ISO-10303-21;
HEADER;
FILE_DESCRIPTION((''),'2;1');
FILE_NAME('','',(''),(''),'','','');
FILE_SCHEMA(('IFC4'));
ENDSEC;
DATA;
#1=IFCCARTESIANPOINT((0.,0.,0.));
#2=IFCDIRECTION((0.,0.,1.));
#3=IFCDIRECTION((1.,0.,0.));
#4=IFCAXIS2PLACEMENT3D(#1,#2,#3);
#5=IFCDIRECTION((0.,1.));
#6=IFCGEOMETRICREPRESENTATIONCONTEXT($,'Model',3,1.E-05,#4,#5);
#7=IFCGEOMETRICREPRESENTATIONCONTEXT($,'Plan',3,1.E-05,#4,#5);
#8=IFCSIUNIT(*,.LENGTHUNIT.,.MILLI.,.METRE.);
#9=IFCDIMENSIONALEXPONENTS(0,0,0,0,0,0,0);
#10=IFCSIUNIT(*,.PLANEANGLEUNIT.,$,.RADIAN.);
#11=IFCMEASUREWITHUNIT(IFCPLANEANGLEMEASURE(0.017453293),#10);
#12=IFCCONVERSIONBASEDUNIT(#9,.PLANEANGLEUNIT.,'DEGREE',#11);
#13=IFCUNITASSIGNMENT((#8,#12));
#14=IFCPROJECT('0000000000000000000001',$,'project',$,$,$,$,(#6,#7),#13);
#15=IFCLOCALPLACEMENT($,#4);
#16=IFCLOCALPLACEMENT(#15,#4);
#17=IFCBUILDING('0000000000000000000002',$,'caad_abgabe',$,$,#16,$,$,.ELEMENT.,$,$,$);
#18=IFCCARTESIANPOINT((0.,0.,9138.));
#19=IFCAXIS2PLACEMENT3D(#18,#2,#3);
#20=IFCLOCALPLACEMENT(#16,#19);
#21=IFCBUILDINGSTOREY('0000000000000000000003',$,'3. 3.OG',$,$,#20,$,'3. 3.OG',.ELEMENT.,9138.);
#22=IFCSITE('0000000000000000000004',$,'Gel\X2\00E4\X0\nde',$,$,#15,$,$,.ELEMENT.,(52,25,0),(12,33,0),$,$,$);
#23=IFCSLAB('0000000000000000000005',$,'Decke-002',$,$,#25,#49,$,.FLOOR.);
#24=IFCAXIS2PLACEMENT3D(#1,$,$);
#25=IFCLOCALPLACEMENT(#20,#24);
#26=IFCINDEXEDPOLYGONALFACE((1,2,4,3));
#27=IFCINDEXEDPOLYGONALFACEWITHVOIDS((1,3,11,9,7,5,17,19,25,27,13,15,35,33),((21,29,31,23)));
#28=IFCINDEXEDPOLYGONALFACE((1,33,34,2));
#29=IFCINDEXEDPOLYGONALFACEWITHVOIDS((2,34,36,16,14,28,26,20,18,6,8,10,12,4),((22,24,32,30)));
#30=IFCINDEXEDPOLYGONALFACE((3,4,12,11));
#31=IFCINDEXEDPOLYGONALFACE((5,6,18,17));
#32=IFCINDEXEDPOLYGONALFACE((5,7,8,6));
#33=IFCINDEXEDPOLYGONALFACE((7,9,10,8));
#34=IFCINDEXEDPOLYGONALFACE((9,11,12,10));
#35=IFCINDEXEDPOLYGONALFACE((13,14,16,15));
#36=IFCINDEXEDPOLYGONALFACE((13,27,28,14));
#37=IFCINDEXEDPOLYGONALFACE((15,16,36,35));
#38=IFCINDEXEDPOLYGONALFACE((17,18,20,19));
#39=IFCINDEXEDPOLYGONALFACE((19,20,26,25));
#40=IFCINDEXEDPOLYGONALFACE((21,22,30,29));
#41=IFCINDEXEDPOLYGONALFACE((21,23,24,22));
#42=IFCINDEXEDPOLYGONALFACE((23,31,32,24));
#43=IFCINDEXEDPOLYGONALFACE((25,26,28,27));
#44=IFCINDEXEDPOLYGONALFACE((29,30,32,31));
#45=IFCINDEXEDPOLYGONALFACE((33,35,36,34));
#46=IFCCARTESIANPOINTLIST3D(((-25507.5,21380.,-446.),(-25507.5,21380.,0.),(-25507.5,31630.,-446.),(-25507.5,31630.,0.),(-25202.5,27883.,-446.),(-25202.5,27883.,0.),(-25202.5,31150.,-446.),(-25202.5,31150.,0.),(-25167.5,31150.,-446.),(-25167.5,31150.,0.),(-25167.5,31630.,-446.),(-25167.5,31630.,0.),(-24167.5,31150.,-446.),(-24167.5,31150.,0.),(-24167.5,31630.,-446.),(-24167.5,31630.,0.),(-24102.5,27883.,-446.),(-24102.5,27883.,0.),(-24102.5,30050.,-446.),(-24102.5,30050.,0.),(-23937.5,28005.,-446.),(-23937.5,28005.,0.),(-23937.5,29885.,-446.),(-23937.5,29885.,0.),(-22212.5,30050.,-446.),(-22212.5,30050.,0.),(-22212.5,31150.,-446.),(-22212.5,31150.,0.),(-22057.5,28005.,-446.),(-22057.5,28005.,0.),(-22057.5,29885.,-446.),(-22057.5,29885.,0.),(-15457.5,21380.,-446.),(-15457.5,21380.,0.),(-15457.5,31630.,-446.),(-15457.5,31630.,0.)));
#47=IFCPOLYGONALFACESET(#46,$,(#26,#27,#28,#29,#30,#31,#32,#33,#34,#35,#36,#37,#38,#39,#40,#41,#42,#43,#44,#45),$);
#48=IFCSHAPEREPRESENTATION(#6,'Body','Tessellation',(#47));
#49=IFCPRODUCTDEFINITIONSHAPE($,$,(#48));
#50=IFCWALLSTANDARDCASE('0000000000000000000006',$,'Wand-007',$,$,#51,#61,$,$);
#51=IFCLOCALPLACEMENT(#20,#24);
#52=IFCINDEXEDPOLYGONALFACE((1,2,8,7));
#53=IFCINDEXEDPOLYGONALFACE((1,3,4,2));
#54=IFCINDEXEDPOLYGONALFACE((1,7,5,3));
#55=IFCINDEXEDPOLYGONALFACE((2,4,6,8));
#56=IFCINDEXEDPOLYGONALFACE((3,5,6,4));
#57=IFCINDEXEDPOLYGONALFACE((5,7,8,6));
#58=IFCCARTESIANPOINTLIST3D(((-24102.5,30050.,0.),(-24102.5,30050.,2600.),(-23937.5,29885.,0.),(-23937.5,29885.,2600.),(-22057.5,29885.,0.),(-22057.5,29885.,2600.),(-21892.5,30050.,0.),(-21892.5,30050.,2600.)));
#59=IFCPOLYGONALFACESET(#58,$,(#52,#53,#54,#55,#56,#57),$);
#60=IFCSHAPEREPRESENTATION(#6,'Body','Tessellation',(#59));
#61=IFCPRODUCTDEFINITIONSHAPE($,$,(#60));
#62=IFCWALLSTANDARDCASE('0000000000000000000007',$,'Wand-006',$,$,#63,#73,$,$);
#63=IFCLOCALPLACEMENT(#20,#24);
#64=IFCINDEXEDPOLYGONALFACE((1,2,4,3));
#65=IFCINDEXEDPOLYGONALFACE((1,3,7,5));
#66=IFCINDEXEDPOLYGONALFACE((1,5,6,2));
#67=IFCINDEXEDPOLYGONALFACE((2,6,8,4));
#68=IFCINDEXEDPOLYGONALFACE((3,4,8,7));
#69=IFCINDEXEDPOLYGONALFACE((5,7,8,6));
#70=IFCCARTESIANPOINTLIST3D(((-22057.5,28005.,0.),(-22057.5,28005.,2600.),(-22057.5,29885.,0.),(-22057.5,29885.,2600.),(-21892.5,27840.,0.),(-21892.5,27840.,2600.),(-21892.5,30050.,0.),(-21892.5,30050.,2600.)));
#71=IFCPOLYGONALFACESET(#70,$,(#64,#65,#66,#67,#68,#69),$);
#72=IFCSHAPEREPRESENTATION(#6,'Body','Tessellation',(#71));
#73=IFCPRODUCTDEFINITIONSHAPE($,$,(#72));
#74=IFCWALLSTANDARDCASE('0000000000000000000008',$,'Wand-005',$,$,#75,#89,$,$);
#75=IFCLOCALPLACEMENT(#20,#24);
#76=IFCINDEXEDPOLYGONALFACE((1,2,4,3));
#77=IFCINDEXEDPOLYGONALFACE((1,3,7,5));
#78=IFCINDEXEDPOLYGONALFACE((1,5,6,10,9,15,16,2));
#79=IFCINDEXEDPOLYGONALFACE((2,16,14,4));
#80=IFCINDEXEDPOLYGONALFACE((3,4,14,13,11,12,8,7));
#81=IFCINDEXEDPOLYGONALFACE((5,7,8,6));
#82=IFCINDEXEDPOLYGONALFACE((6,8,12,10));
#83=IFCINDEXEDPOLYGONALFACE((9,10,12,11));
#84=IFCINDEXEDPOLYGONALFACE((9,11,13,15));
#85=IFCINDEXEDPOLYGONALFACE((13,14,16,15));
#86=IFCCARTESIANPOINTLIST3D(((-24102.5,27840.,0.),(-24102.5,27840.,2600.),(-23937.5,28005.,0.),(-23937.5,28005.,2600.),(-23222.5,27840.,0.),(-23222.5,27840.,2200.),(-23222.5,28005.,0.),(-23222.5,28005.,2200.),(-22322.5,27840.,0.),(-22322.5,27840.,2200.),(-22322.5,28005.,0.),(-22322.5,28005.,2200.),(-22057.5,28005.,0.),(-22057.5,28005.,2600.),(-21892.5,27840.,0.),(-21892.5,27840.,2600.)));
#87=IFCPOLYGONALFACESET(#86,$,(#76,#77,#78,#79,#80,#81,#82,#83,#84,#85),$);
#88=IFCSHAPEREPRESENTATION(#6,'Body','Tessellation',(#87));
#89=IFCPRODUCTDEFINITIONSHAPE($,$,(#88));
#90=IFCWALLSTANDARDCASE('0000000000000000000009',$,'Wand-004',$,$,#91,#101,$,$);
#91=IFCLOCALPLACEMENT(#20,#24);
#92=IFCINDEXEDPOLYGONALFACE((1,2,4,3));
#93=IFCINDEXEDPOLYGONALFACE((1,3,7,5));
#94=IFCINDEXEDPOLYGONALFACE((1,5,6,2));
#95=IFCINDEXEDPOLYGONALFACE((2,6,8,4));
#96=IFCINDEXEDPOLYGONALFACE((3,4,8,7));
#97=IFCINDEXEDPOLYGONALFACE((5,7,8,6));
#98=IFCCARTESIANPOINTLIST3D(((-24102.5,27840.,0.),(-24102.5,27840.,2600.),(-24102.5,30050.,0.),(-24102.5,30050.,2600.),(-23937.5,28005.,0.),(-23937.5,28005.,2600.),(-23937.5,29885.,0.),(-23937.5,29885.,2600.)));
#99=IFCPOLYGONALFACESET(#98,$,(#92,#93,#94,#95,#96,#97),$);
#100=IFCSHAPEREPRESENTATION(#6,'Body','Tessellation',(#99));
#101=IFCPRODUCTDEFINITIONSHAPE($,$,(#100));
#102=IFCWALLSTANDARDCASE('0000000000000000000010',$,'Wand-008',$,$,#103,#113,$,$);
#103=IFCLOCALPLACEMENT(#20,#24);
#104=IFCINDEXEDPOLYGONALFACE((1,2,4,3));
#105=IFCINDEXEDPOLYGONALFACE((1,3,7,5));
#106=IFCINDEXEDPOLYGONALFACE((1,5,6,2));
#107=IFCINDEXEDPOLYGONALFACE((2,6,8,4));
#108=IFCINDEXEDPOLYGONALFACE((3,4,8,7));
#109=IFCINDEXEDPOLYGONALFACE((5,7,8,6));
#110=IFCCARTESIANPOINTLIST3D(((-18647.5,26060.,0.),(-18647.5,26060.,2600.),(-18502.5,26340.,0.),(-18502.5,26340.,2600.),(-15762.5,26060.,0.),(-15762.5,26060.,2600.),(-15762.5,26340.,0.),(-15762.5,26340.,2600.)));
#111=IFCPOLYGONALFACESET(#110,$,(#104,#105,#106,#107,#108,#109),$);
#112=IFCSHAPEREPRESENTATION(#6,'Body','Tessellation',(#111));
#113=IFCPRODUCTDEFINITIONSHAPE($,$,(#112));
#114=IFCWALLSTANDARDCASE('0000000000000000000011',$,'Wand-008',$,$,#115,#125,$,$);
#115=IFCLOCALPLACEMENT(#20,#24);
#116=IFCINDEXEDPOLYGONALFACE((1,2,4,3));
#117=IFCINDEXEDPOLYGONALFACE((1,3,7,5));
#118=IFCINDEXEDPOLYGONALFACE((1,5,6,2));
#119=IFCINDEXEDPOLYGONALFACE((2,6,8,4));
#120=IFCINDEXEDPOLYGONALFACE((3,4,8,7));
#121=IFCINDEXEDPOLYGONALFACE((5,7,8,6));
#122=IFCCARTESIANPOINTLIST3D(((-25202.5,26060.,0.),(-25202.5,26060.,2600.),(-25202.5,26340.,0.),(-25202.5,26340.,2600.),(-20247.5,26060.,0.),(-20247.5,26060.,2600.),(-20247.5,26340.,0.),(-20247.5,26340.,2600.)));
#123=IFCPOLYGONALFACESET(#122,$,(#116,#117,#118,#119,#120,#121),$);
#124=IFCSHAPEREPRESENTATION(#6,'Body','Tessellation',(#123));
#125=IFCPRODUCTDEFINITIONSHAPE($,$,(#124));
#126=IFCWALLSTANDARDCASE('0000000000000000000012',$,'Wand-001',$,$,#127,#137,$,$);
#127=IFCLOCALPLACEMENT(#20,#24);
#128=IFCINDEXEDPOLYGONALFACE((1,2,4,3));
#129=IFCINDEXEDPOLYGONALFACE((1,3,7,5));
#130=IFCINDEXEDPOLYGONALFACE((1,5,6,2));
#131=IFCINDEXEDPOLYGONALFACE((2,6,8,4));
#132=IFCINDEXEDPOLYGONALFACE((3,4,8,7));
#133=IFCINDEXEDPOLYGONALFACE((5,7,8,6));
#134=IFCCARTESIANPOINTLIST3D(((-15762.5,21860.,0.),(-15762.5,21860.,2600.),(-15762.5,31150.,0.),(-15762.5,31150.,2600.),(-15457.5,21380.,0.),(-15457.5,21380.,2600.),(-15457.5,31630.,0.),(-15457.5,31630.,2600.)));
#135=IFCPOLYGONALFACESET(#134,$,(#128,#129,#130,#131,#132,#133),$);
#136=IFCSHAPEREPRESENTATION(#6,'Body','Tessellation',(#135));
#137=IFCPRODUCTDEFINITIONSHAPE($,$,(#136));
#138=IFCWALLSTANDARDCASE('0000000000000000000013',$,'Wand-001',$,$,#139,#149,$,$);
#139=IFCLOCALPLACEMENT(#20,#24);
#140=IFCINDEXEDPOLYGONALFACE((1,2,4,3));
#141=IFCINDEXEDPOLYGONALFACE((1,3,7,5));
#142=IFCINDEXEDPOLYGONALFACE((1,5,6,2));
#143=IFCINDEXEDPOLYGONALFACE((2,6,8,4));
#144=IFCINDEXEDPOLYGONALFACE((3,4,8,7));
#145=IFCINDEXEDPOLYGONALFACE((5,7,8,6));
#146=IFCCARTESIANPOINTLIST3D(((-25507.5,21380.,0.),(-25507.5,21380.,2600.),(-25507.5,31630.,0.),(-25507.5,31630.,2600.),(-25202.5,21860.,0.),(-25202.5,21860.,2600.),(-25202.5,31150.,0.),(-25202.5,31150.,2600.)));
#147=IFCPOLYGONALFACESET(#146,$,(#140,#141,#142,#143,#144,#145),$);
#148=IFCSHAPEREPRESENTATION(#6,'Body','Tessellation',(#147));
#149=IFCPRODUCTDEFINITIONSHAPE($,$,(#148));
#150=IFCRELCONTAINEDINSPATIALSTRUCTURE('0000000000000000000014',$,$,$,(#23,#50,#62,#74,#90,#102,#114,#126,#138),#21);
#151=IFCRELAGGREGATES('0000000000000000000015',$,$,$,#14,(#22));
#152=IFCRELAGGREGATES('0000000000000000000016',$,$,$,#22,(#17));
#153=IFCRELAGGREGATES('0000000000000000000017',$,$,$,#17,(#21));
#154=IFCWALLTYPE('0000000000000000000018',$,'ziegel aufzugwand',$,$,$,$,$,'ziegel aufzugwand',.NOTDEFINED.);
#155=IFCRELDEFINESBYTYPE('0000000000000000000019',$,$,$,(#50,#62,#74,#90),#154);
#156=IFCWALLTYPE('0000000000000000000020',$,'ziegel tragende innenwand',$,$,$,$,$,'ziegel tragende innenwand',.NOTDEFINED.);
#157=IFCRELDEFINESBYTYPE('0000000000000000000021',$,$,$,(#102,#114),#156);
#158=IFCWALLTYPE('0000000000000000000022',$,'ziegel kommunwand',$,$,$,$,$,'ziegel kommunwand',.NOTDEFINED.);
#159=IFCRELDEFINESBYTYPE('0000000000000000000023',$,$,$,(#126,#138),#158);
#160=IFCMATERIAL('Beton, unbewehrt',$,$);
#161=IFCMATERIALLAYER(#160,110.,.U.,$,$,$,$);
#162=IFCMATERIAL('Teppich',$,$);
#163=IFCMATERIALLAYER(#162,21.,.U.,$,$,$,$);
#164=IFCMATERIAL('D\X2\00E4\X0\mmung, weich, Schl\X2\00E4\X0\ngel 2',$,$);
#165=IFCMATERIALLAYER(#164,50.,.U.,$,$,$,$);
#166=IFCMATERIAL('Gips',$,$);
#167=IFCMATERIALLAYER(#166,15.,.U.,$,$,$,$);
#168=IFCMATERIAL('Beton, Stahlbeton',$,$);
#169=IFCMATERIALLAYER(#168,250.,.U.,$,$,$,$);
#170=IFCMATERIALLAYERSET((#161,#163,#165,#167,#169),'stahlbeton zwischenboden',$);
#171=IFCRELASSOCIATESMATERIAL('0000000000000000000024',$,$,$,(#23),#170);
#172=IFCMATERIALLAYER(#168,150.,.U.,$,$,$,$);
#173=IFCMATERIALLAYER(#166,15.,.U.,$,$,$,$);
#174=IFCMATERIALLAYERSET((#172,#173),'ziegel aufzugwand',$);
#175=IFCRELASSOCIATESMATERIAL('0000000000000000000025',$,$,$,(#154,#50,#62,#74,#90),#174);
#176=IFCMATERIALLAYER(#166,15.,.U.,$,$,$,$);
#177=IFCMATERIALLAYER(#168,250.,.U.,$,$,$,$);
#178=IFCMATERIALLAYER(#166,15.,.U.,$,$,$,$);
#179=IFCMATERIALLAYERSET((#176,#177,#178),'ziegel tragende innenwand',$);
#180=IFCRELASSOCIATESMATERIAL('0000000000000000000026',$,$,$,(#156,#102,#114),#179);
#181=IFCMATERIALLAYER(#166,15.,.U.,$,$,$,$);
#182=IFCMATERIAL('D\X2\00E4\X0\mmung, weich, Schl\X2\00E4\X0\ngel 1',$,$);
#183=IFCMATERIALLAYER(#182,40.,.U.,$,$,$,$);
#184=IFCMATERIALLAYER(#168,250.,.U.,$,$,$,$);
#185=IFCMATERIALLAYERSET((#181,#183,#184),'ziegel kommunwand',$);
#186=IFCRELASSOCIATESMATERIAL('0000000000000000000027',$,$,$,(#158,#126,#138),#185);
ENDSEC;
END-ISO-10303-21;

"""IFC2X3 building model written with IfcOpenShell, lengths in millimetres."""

from ifc_helpers import new_model, entity, si_unit, converted_unit, direction, frame, frame_2d, origin_with_axes, place, context, project, spatial, polyline, rectangle, outline, extrude, material, layer, layer_set, layer_usage, type_object, element, save


model = new_model("IFC2X3")

# Units and contexts
model_context = context("Model", 3, precision=1e-05, world=origin_with_axes(), true_north=direction((0.0, 1.0)))
plan_context = context("Plan", 3, precision=1e-05, world=origin_with_axes(), true_north=direction((0.0, 1.0)))
ifc_project = project(units=[si_unit("LENGTHUNIT", "METRE", prefix="MILLI"), converted_unit("PLANEANGLEUNIT", "DEGREE", entity("IfcPlaneAngleMeasure", 0.017453293), si_unit("PLANEANGLEUNIT", "RADIAN"), dimensions=[0, 0, 0, 0, 0, 0, 0])], contexts=[model_context, plan_context])

# Site, building, storey
site_placement = place(None, origin_with_axes())
site = spatial("IfcSite", under=ifc_project, at=site_placement, Name="Gelände", CompositionType="ELEMENT", RefLatitude=(52, 25, 0), RefLongitude=(12, 33, 0))
building_placement = place(site_placement, origin_with_axes())
building = spatial("IfcBuilding", under=site, at=building_placement, Name="caad_abgabe", CompositionType="ELEMENT")
storey_placement = place(building_placement, frame((0.0, 0.0, 9138.0), z_axis=(0.0, 0.0, 1.0), x_axis=(1.0, 0.0, 0.0)))
storey = spatial("IfcBuildingStorey", under=building, at=storey_placement, Name="3. 3.OG", LongName="3. 3.OG", CompositionType="ELEMENT", Elevation=9138.0)

# Slab, opening
ifc_material_1 = material(Name="Beton, unbewehrt")
ifc_layer_1 = layer(ifc_material_1, 110.0, ventilated="UNKNOWN")
ifc_material_2 = material(Name="Teppich")
ifc_layer_2 = layer(ifc_material_2, 21.0, ventilated="UNKNOWN")
ifc_material_3 = material(Name="Dämmung, weich, Schlängel 2")
ifc_layer_3 = layer(ifc_material_3, 50.0, ventilated="UNKNOWN")
ifc_material_4 = material(Name="Gips")
ifc_layer_4 = layer(ifc_material_4, 15.0, ventilated="UNKNOWN")
ifc_material_5 = material(Name="Beton, Stahlbeton")
ifc_layer_5 = layer(ifc_material_5, 250.0, ventilated="UNKNOWN")
ifc_layer_set_1 = layer_set([ifc_layer_1, ifc_layer_2, ifc_layer_3, ifc_layer_4, ifc_layer_5], Name="stahlbeton zwischenboden")
ifc_layer_usage_1 = layer_usage(ifc_layer_set_1, "AXIS3", "NEGATIVE", 446.0)
slab_placement = place(storey_placement, frame((-25507.5, 31630.0, -446.0), z_axis=(0.0, 0.0, 1.0), x_axis=(0.0, -1.0, 0.0)))
slab = element("IfcSlab", 1, at=slab_placement, inside=storey, material=ifc_layer_usage_1, Name="Decke-002", PredefinedType="FLOOR", context=model_context, shape_type="SweptSolid", body=[
    extrude(outline(polyline([(0.0, 0.0), (10250.0, 0.0), (10250.0, 10050.0), (0.0, 10050.0), (0.0, 1340.0), (480.0, 1340.0), (480.0, 3295.0), (1580.0, 3295.0), (1580.0, 1405.0), (3747.0, 1405.0), (3747.0, 305.0), (480.0, 305.0), (480.0, 340.0), (0.0, 340.0), (0.0, 0.0)])), origin_with_axes(), (0.0, 0.0, 1.0), 446.0),
])
opening_1_placement = place(slab_placement, origin_with_axes())
element("IfcOpeningElement", 2, at=opening_1_placement, cuts=slab, context=model_context, shape_type="SweptSolid", body=[
    extrude(outline(polyline([(3625.0, 1570.0), (1745.0, 1570.0), (1745.0, 3450.0), (3625.0, 3450.0), (3625.0, 1570.0)])), origin_with_axes(), (0.0, 0.0, 1.0), 446.0),
])

# Walls
ifc_layer_6 = layer(ifc_material_5, 150.0, ventilated="UNKNOWN")
ifc_layer_7 = layer(ifc_material_4, 15.0, ventilated="UNKNOWN")
ifc_layer_set_2 = layer_set([ifc_layer_6, ifc_layer_7], Name="ziegel aufzugwand")
ifc_layer_usage_2 = layer_usage(ifc_layer_set_2, "AXIS2", "POSITIVE", 0.0)
wall_type_1 = type_object("IfcWallType", Name="ziegel aufzugwand", ElementType="ziegel aufzugwand", PredefinedType="NOTDEFINED", material=ifc_layer_set_2)
wall_1_placement = place(storey_placement, frame((-21892.5, 30050.0, 0.0), z_axis=(0.0, 0.0, 1.0), x_axis=(-1.0, 0.0, 0.0)))
element("IfcWallStandardCase", 3, at=wall_1_placement, inside=storey, type_object=wall_type_1, material=ifc_layer_usage_2, Name="Wand-007", context=model_context, shape_type="SweptSolid", body=[
    extrude(outline(polyline([(0.0, 0.0), (2210.0, 0.0), (2045.0, 165.0), (165.0, 165.0), (0.0, 0.0)])), origin_with_axes(), (0.0, 0.0, 1.0), 2600.0),
])
ifc_layer_usage_3 = layer_usage(ifc_layer_set_2, "AXIS2", "POSITIVE", 0.0)
wall_2_placement = place(storey_placement, frame((-21892.5, 27840.0, 0.0), z_axis=(0.0, 0.0, 1.0), x_axis=(0.0, 1.0, 0.0)))
element("IfcWallStandardCase", 4, at=wall_2_placement, inside=storey, type_object=wall_type_1, material=ifc_layer_usage_3, Name="Wand-006", context=model_context, shape_type="SweptSolid", body=[
    extrude(outline(polyline([(0.0, 0.0), (2210.0, 0.0), (2045.0, 165.0), (165.0, 165.0), (0.0, 0.0)])), origin_with_axes(), (0.0, 0.0, 1.0), 2600.0),
])

# Wall, opening
ifc_layer_usage_4 = layer_usage(ifc_layer_set_2, "AXIS2", "POSITIVE", 0.0)
wall_3_placement = place(storey_placement, frame((-24102.5, 27840.0, 0.0), z_axis=(0.0, 0.0, 1.0), x_axis=(1.0, 0.0, 0.0)))
wall_3 = element("IfcWallStandardCase", 5, at=wall_3_placement, inside=storey, type_object=wall_type_1, material=ifc_layer_usage_4, Name="Wand-005", context=model_context, shape_type="SweptSolid", body=[
    extrude(outline(polyline([(0.0, 0.0), (2210.0, 0.0), (2045.0, 165.0), (165.0, 165.0), (0.0, 0.0)])), origin_with_axes(), (0.0, 0.0, 1.0), 2600.0),
])
opening_2_placement = place(wall_3_placement, frame((1330.0, 0.0, 0.0), z_axis=(0.0, 0.0, 1.0), x_axis=(1.0, 0.0, 0.0)))
element("IfcOpeningElement", 6, at=opening_2_placement, cuts=wall_3, ObjectType="Opening", context=model_context, shape_type="SweptSolid", body=[
    extrude(rectangle(XDim=900.0, YDim=2200.0, at=frame_2d((0.0, 1100.0), x_axis=(-1.0, 0.0))), frame((0.0, 0.0, 0.0), z_axis=(0.0, 1.0, 0.0), x_axis=(-1.0, 0.0, 0.0)), (0.0, 0.0, 1.0), 165.0),
])

# Walls
ifc_layer_usage_5 = layer_usage(ifc_layer_set_2, "AXIS2", "POSITIVE", 0.0)
wall_4_placement = place(storey_placement, frame((-24102.5, 30050.0, 0.0), z_axis=(0.0, 0.0, 1.0), x_axis=(0.0, -1.0, 0.0)))
element("IfcWallStandardCase", 7, at=wall_4_placement, inside=storey, type_object=wall_type_1, material=ifc_layer_usage_5, Name="Wand-004", context=model_context, shape_type="SweptSolid", body=[
    extrude(outline(polyline([(0.0, 0.0), (2210.0, 0.0), (2045.0, 165.0), (165.0, 165.0), (0.0, 0.0)])), origin_with_axes(), (0.0, 0.0, 1.0), 2600.0),
])
ifc_layer_8 = layer(ifc_material_4, 15.0, ventilated="UNKNOWN")
ifc_layer_9 = layer(ifc_material_5, 250.0, ventilated="UNKNOWN")
ifc_layer_10 = layer(ifc_material_4, 15.0, ventilated="UNKNOWN")
ifc_layer_set_3 = layer_set([ifc_layer_8, ifc_layer_9, ifc_layer_10], Name="ziegel tragende innenwand")
ifc_layer_usage_6 = layer_usage(ifc_layer_set_3, "AXIS2", "NEGATIVE", 0.0)
wall_type_2 = type_object("IfcWallType", Name="ziegel tragende innenwand", ElementType="ziegel tragende innenwand", PredefinedType="NOTDEFINED", material=ifc_layer_set_3)
wall_5_placement = place(storey_placement, frame((-18647.5, 26340.0, 0.0), z_axis=(0.0, 0.0, 1.0), x_axis=(1.0, 0.0, 0.0)))
element("IfcWallStandardCase", 8, at=wall_5_placement, inside=storey, type_object=wall_type_2, material=ifc_layer_usage_6, Name="Wand-008", context=model_context, shape_type="SweptSolid", body=[
    extrude(outline(polyline([(0.0, -280.0), (2885.0, -280.0), (2885.0, 0.0), (145.0, 0.0), (0.0, -280.0)])), origin_with_axes(), (0.0, 0.0, 1.0), 2600.0),
])
ifc_layer_usage_7 = layer_usage(ifc_layer_set_3, "AXIS2", "NEGATIVE", 0.0)
wall_6_placement = place(storey_placement, frame((-25202.5, 26340.0, 0.0), z_axis=(0.0, 0.0, 1.0), x_axis=(1.0, 0.0, 0.0)))
element("IfcWallStandardCase", 9, at=wall_6_placement, inside=storey, type_object=wall_type_2, material=ifc_layer_usage_7, Name="Wand-008", context=model_context, shape_type="SweptSolid", body=[
    extrude(outline(polyline([(0.0, -280.0), (4955.0, -280.0), (4955.0, 0.0), (0.0, 0.0), (0.0, -280.0)])), origin_with_axes(), (0.0, 0.0, 1.0), 2600.0),
])
ifc_layer_11 = layer(ifc_material_4, 15.0, ventilated="UNKNOWN")
ifc_material_6 = material(Name="Dämmung, weich, Schlängel 1")
ifc_layer_12 = layer(ifc_material_6, 40.0, ventilated="UNKNOWN")
ifc_layer_13 = layer(ifc_material_5, 250.0, ventilated="UNKNOWN")
ifc_layer_set_4 = layer_set([ifc_layer_11, ifc_layer_12, ifc_layer_13], Name="ziegel kommunwand")
ifc_layer_usage_8 = layer_usage(ifc_layer_set_4, "AXIS2", "NEGATIVE", 0.0)
wall_type_3 = type_object("IfcWallType", Name="ziegel kommunwand", ElementType="ziegel kommunwand", PredefinedType="NOTDEFINED", material=ifc_layer_set_4)
wall_7_placement = place(storey_placement, frame((-15457.5, 31630.0, 0.0), z_axis=(0.0, 0.0, 1.0), x_axis=(0.0, -1.0, 0.0)))
element("IfcWallStandardCase", 10, at=wall_7_placement, inside=storey, type_object=wall_type_3, material=ifc_layer_usage_8, Name="Wand-001", context=model_context, shape_type="SweptSolid", body=[
    extrude(outline(polyline([(480.0, -305.0), (9770.0, -305.0), (10250.0, 0.0), (0.0, 0.0), (480.0, -305.0)])), origin_with_axes(), (0.0, 0.0, 1.0), 2600.0),
])
ifc_layer_usage_9 = layer_usage(ifc_layer_set_4, "AXIS2", "POSITIVE", 0.0)
wall_8_placement = place(storey_placement, frame((-25507.5, 31630.0, 0.0), z_axis=(0.0, 0.0, 1.0), x_axis=(0.0, -1.0, 0.0)))
element("IfcWallStandardCase", 11, at=wall_8_placement, inside=storey, type_object=wall_type_3, material=ifc_layer_usage_9, Name="Wand-001", context=model_context, shape_type="SweptSolid", body=[
    extrude(outline(polyline([(0.0, 0.0), (10250.0, 0.0), (9770.0, 305.0), (480.0, 305.0), (0.0, 0.0)])), origin_with_axes(), (0.0, 0.0, 1.0), 2600.0),
])

save(model, "model.ifc")
